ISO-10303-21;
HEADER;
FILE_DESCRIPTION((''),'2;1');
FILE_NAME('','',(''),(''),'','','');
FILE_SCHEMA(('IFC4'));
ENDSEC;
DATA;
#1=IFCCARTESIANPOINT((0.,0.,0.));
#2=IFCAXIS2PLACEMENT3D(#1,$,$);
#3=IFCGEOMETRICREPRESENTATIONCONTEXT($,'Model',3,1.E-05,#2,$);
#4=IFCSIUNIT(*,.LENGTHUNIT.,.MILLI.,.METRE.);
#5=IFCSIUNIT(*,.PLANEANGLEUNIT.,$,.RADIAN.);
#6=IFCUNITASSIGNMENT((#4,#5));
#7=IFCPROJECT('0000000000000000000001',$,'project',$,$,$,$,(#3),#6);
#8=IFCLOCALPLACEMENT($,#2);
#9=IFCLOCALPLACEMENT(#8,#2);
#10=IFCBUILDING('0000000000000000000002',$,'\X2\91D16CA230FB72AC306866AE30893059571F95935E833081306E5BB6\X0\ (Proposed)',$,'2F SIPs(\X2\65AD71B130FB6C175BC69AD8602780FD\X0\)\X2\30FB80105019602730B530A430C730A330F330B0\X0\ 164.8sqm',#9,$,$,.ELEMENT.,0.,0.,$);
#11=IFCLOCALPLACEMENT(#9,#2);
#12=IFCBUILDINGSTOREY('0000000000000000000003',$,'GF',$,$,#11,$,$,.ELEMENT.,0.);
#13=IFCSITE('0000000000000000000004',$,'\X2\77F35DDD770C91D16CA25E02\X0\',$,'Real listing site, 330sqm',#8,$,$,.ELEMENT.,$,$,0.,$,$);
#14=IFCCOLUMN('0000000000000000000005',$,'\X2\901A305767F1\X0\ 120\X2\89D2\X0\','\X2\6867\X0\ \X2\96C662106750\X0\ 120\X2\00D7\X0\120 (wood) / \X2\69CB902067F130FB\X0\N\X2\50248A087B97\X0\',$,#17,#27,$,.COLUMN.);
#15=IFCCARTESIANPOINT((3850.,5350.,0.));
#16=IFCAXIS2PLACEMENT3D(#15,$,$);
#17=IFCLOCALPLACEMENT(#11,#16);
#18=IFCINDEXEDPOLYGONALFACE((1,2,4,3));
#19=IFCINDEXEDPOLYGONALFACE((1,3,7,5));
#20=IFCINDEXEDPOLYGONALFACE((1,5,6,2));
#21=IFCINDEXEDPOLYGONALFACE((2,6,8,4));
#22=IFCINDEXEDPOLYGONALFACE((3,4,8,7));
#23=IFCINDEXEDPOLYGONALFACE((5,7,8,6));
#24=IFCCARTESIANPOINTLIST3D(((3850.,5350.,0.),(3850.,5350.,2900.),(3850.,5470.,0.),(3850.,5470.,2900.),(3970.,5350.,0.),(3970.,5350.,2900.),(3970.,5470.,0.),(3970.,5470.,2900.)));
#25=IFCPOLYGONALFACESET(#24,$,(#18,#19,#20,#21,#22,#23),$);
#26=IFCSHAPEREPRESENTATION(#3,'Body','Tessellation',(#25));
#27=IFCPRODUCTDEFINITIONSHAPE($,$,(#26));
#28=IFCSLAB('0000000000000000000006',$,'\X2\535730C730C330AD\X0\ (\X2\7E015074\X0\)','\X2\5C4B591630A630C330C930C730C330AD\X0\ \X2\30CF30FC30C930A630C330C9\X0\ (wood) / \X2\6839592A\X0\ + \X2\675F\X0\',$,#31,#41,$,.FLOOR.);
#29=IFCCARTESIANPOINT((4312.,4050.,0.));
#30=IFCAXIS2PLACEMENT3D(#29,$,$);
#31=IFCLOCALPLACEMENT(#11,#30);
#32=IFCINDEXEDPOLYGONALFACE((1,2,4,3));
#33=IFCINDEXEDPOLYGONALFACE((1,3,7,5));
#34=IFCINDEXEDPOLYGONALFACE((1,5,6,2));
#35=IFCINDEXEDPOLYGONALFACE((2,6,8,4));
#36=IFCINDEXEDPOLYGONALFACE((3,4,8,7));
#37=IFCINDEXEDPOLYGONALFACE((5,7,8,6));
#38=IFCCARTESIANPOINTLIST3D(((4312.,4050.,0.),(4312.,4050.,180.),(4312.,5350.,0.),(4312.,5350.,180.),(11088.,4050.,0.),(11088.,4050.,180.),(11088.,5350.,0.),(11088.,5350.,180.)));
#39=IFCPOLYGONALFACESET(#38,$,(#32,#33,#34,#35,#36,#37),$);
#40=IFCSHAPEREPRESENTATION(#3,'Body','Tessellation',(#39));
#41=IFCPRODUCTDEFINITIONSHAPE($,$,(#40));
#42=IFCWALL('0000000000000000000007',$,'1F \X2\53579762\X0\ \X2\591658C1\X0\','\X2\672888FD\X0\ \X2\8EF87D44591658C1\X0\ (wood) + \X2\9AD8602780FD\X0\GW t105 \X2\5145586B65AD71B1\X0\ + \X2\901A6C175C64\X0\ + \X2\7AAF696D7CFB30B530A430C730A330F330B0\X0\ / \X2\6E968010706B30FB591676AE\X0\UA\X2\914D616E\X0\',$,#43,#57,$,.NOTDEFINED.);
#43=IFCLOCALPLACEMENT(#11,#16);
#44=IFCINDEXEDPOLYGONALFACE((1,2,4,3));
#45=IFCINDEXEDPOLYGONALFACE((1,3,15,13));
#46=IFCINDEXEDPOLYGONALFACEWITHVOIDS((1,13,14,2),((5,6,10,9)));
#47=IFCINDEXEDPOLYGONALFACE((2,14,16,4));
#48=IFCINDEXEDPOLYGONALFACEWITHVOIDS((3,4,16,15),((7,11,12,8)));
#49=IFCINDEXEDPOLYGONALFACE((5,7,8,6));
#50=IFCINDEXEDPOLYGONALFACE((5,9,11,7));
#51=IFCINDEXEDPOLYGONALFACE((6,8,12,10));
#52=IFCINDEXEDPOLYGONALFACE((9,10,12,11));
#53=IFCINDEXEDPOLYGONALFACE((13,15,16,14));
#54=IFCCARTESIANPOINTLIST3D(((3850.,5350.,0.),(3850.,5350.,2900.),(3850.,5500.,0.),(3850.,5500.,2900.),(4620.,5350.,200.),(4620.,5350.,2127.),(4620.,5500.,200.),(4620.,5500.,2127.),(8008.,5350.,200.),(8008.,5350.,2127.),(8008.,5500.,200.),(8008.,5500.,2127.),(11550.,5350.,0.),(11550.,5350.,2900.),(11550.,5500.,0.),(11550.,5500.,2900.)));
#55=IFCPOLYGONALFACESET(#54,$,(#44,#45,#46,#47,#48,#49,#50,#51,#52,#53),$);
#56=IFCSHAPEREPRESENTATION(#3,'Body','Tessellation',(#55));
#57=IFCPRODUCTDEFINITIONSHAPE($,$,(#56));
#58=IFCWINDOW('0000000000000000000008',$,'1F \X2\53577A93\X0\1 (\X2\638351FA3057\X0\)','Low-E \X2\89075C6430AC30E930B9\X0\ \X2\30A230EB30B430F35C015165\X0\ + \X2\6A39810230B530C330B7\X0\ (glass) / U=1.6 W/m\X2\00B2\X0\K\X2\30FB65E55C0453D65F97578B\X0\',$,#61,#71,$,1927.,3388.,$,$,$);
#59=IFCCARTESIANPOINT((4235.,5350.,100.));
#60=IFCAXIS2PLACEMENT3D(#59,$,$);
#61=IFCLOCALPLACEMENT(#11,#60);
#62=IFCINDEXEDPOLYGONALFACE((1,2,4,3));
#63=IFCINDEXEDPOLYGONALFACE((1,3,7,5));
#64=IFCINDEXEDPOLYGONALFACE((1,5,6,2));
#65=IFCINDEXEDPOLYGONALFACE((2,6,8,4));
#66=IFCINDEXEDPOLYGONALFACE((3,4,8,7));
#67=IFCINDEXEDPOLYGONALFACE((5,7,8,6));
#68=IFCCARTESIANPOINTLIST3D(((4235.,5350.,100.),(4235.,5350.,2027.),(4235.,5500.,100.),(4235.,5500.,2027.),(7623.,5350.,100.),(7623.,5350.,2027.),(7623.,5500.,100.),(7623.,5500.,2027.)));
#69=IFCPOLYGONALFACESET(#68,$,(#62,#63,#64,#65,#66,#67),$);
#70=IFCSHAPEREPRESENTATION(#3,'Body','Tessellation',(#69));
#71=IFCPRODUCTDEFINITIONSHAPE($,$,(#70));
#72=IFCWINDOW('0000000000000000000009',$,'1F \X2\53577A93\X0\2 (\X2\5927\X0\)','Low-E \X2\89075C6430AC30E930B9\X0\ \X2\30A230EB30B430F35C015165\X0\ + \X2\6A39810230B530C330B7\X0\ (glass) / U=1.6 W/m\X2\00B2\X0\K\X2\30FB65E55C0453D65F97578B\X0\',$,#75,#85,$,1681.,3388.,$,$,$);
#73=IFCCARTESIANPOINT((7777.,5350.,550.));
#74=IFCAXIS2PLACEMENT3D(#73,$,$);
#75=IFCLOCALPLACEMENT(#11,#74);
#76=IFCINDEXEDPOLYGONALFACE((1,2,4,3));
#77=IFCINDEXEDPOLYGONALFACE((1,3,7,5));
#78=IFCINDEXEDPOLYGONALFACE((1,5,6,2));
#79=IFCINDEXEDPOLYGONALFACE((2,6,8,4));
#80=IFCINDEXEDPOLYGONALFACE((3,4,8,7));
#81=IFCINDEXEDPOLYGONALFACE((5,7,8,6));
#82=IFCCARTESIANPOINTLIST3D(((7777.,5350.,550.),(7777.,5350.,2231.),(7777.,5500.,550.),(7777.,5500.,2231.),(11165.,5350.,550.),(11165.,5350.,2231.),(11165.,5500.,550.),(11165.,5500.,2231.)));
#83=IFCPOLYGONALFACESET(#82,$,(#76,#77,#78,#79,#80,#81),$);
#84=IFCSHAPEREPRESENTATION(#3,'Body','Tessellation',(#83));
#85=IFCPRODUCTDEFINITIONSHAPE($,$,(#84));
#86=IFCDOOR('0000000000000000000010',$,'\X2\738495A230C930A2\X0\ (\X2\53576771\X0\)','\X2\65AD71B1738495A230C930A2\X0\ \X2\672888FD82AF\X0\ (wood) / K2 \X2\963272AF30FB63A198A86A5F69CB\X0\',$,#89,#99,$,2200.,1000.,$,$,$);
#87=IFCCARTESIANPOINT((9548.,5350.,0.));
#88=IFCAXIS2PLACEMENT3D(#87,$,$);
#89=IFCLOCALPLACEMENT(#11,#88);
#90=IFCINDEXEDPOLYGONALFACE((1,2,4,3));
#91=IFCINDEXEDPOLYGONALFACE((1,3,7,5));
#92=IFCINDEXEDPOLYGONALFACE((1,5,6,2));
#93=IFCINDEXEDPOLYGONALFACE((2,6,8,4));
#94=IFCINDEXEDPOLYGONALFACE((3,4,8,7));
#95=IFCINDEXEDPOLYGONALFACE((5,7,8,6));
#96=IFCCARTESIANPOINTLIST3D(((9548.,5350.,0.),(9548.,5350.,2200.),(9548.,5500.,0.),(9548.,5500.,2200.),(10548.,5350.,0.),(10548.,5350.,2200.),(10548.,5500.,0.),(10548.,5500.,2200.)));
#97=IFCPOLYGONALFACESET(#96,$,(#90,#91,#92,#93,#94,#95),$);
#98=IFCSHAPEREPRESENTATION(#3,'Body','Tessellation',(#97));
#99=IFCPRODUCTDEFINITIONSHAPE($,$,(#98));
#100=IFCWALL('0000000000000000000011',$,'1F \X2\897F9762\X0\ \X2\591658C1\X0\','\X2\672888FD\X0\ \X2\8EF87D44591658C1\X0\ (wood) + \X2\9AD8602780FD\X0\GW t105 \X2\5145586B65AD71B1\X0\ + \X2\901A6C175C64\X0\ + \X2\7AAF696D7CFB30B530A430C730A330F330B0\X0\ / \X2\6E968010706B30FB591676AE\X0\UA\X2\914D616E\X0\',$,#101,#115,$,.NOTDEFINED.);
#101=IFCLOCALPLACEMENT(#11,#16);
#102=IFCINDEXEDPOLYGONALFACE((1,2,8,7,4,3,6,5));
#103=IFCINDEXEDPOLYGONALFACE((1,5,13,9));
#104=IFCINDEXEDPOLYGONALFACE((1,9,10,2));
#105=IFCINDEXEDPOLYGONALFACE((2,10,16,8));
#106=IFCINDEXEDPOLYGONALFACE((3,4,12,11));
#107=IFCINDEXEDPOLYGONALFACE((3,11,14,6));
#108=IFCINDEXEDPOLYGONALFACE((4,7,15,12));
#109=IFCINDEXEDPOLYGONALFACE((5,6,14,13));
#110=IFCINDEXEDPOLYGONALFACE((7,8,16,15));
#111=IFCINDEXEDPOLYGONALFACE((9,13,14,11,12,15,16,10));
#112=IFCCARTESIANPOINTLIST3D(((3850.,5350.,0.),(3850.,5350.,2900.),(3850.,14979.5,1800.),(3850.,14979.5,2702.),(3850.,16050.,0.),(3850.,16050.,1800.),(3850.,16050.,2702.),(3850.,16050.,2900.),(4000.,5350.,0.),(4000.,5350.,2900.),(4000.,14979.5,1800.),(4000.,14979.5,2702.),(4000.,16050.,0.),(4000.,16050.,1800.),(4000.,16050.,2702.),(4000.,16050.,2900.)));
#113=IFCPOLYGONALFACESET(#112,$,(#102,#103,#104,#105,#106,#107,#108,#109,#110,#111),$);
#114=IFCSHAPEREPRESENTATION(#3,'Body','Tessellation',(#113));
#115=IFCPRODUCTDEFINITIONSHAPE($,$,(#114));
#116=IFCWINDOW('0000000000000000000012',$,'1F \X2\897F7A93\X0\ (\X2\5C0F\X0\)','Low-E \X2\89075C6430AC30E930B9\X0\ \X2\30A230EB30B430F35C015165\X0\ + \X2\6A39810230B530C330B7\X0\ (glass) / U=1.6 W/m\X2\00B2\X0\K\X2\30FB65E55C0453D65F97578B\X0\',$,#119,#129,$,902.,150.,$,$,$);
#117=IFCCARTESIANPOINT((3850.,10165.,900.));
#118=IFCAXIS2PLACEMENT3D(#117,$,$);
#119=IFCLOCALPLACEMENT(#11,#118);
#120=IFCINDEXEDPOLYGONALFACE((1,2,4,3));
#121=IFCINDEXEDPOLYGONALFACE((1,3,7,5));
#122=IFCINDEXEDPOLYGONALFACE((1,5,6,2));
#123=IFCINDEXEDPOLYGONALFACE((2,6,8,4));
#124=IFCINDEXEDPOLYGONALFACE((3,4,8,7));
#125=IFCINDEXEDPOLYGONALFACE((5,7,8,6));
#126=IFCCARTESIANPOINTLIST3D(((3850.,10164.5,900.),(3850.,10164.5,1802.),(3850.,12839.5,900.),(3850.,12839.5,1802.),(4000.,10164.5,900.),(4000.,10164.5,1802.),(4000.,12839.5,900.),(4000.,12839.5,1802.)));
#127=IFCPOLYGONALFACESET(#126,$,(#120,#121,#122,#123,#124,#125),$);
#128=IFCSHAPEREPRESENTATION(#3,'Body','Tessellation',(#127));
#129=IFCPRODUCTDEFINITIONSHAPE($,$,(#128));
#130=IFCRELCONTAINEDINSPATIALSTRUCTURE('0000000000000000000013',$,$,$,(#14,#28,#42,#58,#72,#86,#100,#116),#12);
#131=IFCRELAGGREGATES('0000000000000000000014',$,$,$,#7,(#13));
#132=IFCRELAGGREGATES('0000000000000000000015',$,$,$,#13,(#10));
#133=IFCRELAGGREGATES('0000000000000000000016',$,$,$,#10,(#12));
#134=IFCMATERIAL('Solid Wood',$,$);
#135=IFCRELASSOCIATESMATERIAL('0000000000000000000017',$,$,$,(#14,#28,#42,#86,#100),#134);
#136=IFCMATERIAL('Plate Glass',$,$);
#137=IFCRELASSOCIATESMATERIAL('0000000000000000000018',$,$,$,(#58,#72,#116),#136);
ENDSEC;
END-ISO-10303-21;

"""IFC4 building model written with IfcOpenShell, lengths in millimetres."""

from ifc_helpers import new_model, si_unit, frame, frame_2d, origin, place, context, project, spatial, rectangle, extrude, material, element, fill, save


model = new_model("IFC4")

# Units and contexts
model_context = context("Model", 3, precision=1e-05, world=origin())
ifc_project = project(units=[si_unit("LENGTHUNIT", "METRE", prefix="MILLI"), si_unit("PLANEANGLEUNIT", "RADIAN")], contexts=[model_context])

# Site, building, storey
site_placement = place(None, origin())
site = spatial("IfcSite", under=ifc_project, at=site_placement, Name="石川県金沢市", ObjectType="Real listing site, 330sqm", CompositionType="ELEMENT", RefElevation=0.0)
building_placement = place(site_placement, origin())
building = spatial("IfcBuilding", under=site, at=building_placement, Name="金沢・犬と暮らす土間広めの家 (Proposed)", ObjectType="2F SIPs(断熱・気密高性能)・耐候性サイディング 164.8sqm", CompositionType="ELEMENT", ElevationOfRefHeight=0.0, ElevationOfTerrain=0.0)
storey_placement = place(building_placement, origin())
storey = spatial("IfcBuildingStorey", under=building, at=storey_placement, Name="GF", CompositionType="ELEMENT", Elevation=0.0)

# Column
ifc_material_1 = material(Name="Solid Wood")
column_placement = place(storey_placement, frame((3850.0, 5350.0, 0.0)))
element("IfcColumn", 1, at=column_placement, inside=storey, material=ifc_material_1, Name="通し柱 120角", Description="桧 集成材 120×120 (wood) / 構造柱・N値計算", PredefinedType="COLUMN", context=model_context, shape_type="SweptSolid", body=[
    extrude(rectangle(XDim=120.0, YDim=120.0, at=frame_2d((60.0, 60.0))), frame((3850.0, 5350.0, 0.0)), (0.0, 0.0, 1.0), 2900.0),
])

# Slab
slab_1_placement = place(storey_placement, frame((4312.0, 4050.0, 0.0)))
element("IfcSlab", 2, at=slab_1_placement, inside=storey, material=ifc_material_1, Name="南デッキ (縁側)", Description="屋外ウッドデッキ ハードウッド (wood) / 根太 + 束", PredefinedType="FLOOR", context=model_context, shape_type="SweptSolid", body=[
    extrude(rectangle(XDim=6776.0, YDim=1300.0, at=frame_2d((3388.0, 650.0))), frame((4312.0, 4050.0, 0.0)), (0.0, 0.0, 1.0), 180.0),
])

# Wall, openings, windows, door
wall_1_placement = place(storey_placement, frame((3850.0, 5350.0, 0.0)))
wall_1 = element("IfcWall", 3, at=wall_1_placement, inside=storey, material=ifc_material_1, Name="1F 南面 外壁", Description="木製 軸組外壁 (wood) + 高性能GW t105 充填断熱 + 通気層 + 窯業系サイディング / 準耐火・外皮UA配慮", PredefinedType="NOTDEFINED", context=model_context, shape_type="SweptSolid", body=[
    extrude(rectangle(XDim=7700.0, YDim=150.0, at=frame_2d((3850.0, 75.0))), frame((3850.0, 5350.0, 0.0)), (0.0, 0.0, 1.0), 2900.0),
])
opening_1_placement = place(storey_placement, frame((4235.0, 5350.0, 100.0)))
opening_1 = element("IfcOpeningElement", 4, at=opening_1_placement, cuts=wall_1, PredefinedType="NOTDEFINED", context=model_context, shape_type="SweptSolid", body=[
    extrude(rectangle(XDim=3388.0, YDim=150.0, at=frame_2d((1694.0, 75.0))), frame((4235.0, 5350.0, 100.0)), (0.0, 0.0, 1.0), 1927.0),
])
opening_2_placement = place(storey_placement, frame((7777.0, 5350.0, 550.0)))
opening_2 = element("IfcOpeningElement", 5, at=opening_2_placement, cuts=wall_1, PredefinedType="NOTDEFINED", context=model_context, shape_type="SweptSolid", body=[
    extrude(rectangle(XDim=3388.0, YDim=150.0, at=frame_2d((1694.0, 75.0))), frame((7777.0, 5350.0, 550.0)), (0.0, 0.0, 1.0), 1681.0),
])
opening_3_placement = place(storey_placement, frame((9548.0, 5350.0, 0.0)))
opening_3 = element("IfcOpeningElement", 6, at=opening_3_placement, cuts=wall_1, PredefinedType="NOTDEFINED", context=model_context, shape_type="SweptSolid", body=[
    extrude(rectangle(XDim=1000.0, YDim=150.0, at=frame_2d((500.0, 75.0))), frame((9548.0, 5350.0, 0.0)), (0.0, 0.0, 1.0), 2200.0),
])
ifc_material_2 = material(Name="Plate Glass")
window_1_placement = place(storey_placement, frame((4235.0, 5350.0, 100.0)))
window_1 = element("IfcWindow", 7, at=window_1_placement, inside=storey, material=ifc_material_2, Name="1F 南窓1 (掃出し)", Description="Low-E 複層ガラス アルゴン封入 + 樹脂サッシ (glass) / U=1.6 W/m²K・日射取得型", OverallHeight=1927.0, OverallWidth=3388.0, context=model_context, shape_type="SweptSolid", body=[
    extrude(rectangle(XDim=3388.0, YDim=150.0, at=frame_2d((1694.0, 75.0))), frame((4235.0, 5350.0, 100.0)), (0.0, 0.0, 1.0), 1927.0),
])
fill(opening_1, window_1)
window_2_placement = place(storey_placement, frame((7777.0, 5350.0, 550.0)))
window_2 = element("IfcWindow", 8, at=window_2_placement, inside=storey, material=ifc_material_2, Name="1F 南窓2 (大)", Description="Low-E 複層ガラス アルゴン封入 + 樹脂サッシ (glass) / U=1.6 W/m²K・日射取得型", OverallHeight=1681.0, OverallWidth=3388.0, context=model_context, shape_type="SweptSolid", body=[
    extrude(rectangle(XDim=3388.0, YDim=150.0, at=frame_2d((1694.0, 75.0))), frame((7777.0, 5350.0, 550.0)), (0.0, 0.0, 1.0), 1681.0),
])
fill(opening_2, window_2)
door_placement = place(storey_placement, frame((9548.0, 5350.0, 0.0)))
door = element("IfcDoor", 9, at=door_placement, inside=storey, material=ifc_material_1, Name="玄関ドア (南東)", Description="断熱玄関ドア 木製芯 (wood) / K2 防犯・採風機構", OverallHeight=2200.0, OverallWidth=1000.0, context=model_context, shape_type="SweptSolid", body=[
    extrude(rectangle(XDim=1000.0, YDim=150.0, at=frame_2d((500.0, 75.0))), frame((9548.0, 5350.0, 0.0)), (0.0, 0.0, 1.0), 2200.0),
])
fill(opening_3, door)

# Wall, opening, window
wall_2_placement = place(storey_placement, frame((3850.0, 5350.0, 0.0)))
wall_2 = element("IfcWall", 10, at=wall_2_placement, inside=storey, material=ifc_material_1, Name="1F 西面 外壁", Description="木製 軸組外壁 (wood) + 高性能GW t105 充填断熱 + 通気層 + 窯業系サイディング / 準耐火・外皮UA配慮", PredefinedType="NOTDEFINED", context=model_context, shape_type="SweptSolid", body=[
    extrude(rectangle(XDim=150.0, YDim=10700.0, at=frame_2d((75.0, 5350.0))), frame((3850.0, 5350.0, 0.0)), (0.0, 0.0, 1.0), 2900.0),
])
opening_4_placement = place(storey_placement, frame((3850.0, 10165.0, 900.0)))
opening_4 = element("IfcOpeningElement", 11, at=opening_4_placement, cuts=wall_2, PredefinedType="NOTDEFINED", context=model_context, shape_type="SweptSolid", body=[
    extrude(rectangle(XDim=150.0, YDim=2675.0, at=frame_2d((75.0, 1337.0))), frame((3850.0, 10165.0, 900.0)), (0.0, 0.0, 1.0), 902.0),
])
window_3_placement = place(storey_placement, frame((3850.0, 10165.0, 900.0)))
window_3 = element("IfcWindow", 12, at=window_3_placement, inside=storey, material=ifc_material_2, Name="1F 西窓 (小)", Description="Low-E 複層ガラス アルゴン封入 + 樹脂サッシ (glass) / U=1.6 W/m²K・日射取得型", OverallHeight=902.0, OverallWidth=150.0, context=model_context, shape_type="SweptSolid", body=[
    extrude(rectangle(XDim=150.0, YDim=2675.0, at=frame_2d((75.0, 1337.0))), frame((3850.0, 10165.0, 900.0)), (0.0, 0.0, 1.0), 902.0),
])
fill(opening_4, window_3)

save(model, "model.ifc")
